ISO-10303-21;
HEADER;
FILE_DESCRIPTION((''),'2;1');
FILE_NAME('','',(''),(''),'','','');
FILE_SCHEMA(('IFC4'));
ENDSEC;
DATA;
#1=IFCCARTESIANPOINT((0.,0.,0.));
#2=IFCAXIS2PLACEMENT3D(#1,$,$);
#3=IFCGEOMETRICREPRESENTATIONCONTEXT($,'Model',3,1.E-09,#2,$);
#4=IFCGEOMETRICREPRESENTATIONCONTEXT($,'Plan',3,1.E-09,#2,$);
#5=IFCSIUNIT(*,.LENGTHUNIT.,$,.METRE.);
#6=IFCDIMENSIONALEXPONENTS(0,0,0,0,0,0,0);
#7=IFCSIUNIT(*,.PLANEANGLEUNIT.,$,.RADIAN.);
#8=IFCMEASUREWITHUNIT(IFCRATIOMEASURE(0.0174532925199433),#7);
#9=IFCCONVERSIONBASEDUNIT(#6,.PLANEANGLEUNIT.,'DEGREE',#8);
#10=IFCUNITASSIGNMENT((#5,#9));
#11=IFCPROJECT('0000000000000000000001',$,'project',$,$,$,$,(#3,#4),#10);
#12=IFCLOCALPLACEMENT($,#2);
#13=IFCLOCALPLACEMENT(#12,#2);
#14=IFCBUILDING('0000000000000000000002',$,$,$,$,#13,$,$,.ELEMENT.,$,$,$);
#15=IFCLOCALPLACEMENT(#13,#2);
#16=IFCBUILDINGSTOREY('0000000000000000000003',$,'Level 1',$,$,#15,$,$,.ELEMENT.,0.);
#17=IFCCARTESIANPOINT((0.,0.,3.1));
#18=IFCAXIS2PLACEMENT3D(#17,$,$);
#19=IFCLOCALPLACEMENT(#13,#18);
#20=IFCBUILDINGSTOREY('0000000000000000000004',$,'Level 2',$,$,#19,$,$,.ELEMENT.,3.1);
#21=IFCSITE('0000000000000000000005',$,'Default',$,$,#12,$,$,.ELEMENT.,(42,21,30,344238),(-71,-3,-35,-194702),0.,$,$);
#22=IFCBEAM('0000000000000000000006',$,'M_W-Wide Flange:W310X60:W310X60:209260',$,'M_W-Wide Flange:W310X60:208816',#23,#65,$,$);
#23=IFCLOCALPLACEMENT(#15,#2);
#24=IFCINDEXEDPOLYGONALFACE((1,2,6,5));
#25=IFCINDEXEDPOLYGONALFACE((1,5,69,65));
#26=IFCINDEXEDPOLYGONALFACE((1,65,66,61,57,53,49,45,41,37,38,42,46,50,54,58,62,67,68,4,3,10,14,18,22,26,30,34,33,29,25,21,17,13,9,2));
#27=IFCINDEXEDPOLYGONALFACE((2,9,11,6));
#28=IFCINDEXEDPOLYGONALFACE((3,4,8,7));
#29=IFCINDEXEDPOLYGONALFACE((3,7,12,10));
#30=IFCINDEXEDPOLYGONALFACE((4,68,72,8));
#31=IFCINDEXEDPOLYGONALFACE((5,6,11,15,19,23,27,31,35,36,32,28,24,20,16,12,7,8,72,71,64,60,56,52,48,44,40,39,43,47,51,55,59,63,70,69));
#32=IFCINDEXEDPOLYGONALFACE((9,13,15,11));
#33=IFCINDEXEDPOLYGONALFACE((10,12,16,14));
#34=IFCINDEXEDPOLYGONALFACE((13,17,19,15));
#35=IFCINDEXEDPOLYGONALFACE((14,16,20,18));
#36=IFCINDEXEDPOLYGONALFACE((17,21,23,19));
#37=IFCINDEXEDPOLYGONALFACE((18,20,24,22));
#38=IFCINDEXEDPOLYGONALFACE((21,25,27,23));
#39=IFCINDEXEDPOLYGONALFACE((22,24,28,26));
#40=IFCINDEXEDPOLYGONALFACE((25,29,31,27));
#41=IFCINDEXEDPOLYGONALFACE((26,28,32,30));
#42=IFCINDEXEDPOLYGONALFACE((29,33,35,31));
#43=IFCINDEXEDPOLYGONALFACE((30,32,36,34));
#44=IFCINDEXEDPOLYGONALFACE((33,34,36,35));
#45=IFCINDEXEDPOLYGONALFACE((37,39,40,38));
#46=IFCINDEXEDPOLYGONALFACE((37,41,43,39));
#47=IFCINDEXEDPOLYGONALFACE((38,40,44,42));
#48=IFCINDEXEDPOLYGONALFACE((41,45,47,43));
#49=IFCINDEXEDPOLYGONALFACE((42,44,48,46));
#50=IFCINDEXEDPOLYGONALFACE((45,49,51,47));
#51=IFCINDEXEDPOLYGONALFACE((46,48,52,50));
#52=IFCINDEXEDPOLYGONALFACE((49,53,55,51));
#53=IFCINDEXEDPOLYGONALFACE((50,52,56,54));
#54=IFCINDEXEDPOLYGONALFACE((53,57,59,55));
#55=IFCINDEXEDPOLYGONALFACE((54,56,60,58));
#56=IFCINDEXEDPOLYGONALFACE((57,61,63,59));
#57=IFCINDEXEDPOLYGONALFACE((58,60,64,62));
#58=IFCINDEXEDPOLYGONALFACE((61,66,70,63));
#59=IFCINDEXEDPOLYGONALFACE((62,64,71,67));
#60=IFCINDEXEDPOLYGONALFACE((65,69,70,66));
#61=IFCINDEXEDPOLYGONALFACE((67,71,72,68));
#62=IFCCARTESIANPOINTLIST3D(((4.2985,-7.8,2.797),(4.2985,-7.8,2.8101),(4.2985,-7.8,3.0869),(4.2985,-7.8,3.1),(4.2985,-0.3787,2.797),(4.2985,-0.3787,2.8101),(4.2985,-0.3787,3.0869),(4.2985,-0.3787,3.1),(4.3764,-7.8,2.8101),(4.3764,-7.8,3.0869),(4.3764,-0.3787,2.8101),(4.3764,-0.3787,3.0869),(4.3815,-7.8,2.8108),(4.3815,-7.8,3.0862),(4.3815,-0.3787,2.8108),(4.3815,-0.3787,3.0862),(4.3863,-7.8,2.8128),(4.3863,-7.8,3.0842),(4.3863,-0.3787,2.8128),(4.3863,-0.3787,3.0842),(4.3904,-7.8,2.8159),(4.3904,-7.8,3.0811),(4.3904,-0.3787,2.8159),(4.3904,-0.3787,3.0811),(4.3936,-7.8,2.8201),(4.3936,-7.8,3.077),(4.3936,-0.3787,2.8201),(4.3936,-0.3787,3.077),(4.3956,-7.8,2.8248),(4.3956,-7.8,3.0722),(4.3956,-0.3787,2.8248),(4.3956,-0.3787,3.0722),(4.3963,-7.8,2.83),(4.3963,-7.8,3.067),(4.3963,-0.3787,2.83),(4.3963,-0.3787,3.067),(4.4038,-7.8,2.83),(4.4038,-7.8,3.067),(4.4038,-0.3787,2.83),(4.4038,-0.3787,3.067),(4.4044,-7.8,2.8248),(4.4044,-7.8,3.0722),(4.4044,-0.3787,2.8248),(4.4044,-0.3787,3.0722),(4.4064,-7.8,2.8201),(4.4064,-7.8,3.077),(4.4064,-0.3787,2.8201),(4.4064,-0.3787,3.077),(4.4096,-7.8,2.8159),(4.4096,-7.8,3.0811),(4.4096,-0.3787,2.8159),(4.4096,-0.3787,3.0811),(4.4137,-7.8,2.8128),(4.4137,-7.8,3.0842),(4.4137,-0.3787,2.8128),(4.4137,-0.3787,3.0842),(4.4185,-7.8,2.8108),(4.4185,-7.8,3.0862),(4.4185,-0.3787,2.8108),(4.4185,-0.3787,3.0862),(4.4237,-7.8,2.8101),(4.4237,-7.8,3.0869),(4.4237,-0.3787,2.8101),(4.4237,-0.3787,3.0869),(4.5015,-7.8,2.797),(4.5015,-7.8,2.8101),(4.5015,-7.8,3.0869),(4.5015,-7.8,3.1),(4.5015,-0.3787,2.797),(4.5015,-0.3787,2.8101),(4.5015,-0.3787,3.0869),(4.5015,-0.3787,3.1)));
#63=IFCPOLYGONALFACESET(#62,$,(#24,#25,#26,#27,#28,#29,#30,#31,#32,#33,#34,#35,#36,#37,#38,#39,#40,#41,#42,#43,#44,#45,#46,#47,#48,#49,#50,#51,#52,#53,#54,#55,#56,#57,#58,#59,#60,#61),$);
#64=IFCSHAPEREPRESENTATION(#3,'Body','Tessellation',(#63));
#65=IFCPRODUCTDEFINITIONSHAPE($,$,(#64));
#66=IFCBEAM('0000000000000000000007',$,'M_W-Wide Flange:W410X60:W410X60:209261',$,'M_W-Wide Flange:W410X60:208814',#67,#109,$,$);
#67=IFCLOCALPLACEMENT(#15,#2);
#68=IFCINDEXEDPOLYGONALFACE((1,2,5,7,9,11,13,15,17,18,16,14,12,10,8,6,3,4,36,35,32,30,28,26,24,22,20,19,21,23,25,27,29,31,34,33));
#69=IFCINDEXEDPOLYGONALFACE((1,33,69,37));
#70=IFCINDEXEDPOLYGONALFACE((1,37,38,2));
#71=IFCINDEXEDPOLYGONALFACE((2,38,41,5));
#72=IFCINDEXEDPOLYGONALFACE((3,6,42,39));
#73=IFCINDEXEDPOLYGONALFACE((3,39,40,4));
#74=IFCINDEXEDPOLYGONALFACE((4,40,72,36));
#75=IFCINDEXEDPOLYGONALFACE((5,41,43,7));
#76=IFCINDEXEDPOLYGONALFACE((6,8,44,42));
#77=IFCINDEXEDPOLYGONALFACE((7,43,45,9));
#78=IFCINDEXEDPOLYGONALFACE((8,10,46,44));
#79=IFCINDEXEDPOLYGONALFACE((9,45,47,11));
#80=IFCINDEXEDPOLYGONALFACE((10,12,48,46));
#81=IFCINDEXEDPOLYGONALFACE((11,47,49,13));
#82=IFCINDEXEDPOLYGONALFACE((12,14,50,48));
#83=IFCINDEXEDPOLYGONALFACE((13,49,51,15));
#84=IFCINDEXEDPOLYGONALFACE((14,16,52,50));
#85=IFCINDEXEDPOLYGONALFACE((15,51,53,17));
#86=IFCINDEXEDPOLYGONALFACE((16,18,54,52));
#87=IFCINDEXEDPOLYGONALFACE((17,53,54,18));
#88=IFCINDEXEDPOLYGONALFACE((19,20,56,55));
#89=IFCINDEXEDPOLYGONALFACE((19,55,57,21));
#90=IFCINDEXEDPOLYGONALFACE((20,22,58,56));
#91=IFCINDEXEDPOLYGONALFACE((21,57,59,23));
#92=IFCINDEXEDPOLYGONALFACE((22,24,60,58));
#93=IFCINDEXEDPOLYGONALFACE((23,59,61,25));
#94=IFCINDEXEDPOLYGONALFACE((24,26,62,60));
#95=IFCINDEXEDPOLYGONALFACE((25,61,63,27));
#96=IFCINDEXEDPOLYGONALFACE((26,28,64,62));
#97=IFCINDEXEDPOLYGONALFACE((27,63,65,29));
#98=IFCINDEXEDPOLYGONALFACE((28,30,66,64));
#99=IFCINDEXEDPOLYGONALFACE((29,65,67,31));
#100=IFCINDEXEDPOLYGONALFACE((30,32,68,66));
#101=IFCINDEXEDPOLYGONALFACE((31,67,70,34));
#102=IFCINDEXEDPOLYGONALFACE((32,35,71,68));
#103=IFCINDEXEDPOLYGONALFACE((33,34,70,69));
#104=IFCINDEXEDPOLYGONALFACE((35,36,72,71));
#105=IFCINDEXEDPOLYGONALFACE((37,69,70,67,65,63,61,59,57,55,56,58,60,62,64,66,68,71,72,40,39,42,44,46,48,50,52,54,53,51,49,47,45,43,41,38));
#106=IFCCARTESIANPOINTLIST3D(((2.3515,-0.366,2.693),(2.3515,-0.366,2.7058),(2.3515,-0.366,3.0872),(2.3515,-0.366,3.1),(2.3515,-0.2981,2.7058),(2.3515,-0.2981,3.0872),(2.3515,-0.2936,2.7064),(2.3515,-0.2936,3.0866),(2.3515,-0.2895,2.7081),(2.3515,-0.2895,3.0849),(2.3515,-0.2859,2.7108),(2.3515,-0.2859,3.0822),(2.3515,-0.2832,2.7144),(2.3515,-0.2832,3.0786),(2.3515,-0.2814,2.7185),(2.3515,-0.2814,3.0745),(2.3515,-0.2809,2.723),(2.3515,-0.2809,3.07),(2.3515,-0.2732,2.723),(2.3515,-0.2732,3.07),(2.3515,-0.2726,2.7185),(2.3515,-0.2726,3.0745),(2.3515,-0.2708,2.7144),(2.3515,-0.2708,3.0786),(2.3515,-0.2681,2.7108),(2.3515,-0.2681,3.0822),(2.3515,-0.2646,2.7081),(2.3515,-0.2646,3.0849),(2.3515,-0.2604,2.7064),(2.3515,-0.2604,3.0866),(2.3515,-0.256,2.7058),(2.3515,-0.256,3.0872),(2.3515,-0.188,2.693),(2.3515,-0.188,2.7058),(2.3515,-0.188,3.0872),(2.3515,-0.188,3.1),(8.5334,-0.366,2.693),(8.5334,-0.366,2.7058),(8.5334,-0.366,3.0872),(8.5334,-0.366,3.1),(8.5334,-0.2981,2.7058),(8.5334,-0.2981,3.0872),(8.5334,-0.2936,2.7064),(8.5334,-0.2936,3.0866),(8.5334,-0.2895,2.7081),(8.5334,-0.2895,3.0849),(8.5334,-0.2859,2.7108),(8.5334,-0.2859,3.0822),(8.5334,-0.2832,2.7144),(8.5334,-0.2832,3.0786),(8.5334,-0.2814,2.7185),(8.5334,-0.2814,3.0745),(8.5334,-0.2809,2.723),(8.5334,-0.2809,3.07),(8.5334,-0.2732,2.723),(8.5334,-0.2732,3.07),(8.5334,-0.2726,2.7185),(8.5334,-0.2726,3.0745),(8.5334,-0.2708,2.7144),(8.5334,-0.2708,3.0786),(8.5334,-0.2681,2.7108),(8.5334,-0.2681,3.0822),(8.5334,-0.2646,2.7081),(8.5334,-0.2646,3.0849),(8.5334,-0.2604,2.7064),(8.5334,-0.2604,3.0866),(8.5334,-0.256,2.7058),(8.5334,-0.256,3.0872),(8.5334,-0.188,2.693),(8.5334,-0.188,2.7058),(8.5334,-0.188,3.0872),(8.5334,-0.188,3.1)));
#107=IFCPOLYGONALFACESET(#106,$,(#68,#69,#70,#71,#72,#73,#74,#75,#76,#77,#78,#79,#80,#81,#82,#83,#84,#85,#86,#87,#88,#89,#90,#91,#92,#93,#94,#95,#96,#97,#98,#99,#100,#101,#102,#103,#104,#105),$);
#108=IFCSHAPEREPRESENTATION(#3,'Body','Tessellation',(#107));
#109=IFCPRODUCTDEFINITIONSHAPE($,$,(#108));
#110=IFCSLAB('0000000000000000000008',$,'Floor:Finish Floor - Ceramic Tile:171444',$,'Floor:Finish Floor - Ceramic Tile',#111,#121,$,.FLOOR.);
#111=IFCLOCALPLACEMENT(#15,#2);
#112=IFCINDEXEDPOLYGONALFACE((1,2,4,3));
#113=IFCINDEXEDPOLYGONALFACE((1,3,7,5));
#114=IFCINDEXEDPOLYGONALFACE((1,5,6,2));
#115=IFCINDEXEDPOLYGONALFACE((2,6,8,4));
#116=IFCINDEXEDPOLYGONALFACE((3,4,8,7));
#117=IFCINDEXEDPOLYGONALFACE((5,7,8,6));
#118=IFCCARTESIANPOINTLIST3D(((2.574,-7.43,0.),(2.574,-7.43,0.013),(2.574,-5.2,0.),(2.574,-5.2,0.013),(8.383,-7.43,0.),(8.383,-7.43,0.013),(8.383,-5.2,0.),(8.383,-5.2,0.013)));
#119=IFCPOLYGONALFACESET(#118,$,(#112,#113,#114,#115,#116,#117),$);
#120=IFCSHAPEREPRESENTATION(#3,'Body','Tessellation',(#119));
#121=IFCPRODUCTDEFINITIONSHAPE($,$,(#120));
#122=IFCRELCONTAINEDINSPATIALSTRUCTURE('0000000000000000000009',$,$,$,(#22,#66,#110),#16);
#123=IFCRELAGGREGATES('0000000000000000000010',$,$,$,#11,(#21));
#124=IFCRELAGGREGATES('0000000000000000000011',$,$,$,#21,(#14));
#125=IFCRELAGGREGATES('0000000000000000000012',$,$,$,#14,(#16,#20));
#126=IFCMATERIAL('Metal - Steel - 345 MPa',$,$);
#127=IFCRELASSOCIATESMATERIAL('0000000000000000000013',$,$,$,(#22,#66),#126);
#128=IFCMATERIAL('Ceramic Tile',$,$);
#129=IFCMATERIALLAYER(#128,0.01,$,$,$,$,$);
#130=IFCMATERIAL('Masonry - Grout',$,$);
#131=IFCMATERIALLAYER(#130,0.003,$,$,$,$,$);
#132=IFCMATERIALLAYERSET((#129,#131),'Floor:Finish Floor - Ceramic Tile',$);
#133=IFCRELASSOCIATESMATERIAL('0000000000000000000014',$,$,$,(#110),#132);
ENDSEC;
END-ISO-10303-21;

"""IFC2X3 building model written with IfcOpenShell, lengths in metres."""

from ifc_helpers import new_model, entity, si_unit, converted_unit, frame, frame_2d, origin, place, context, project, spatial, polyline, circle_curve, parameter, trimmed, segment, composite_curve, rectangle, outline, extrude, material, layer, layer_set, layer_usage, element, save


model = new_model("IFC2X3")

# Units and contexts
model_context = context("Model", 3, precision=1e-09, world=origin())
plan_context = context("Plan", 3, precision=1e-09, world=origin())
ifc_project = project(units=[si_unit("LENGTHUNIT", "METRE"), converted_unit("PLANEANGLEUNIT", "DEGREE", entity("IfcRatioMeasure", 0.0174532925199433), si_unit("PLANEANGLEUNIT", "RADIAN"), dimensions=[0, 0, 0, 0, 0, 0, 0])], contexts=[model_context, plan_context])

# Site, building, storey
site_placement = place(None, origin())
site = spatial("IfcSite", under=ifc_project, at=site_placement, Name="Default", CompositionType="ELEMENT", RefLatitude=(42, 21, 30, 344238), RefLongitude=(-71, -3, -35, -194702), RefElevation=0.0)
building_placement = place(site_placement, origin())
building = spatial("IfcBuilding", under=site, at=building_placement, CompositionType="ELEMENT")
storey_1_placement = place(building_placement, origin())
storey_1 = spatial("IfcBuildingStorey", under=building, at=storey_1_placement, Name="Level 1", CompositionType="ELEMENT", Elevation=0.0)

# Beams
ifc_material_1 = material(Name="Metal - Steel - 345 MPa")
beam_1_placement = place(storey_1_placement, frame((4.4, -7.8, 3.1)))
element("IfcBeam", 1, at=beam_1_placement, inside=storey_1, material=ifc_material_1, Name="M_W-Wide Flange:W310X60:W310X60:209260", ObjectType="M_W-Wide Flange:W310X60:208816", context=model_context, shape_type="SweptSolid", body=[
    extrude(outline(composite_curve([segment(polyline([(-0.1015, -0.1384), (-0.1015, -0.1515)]), True, "CONTINUOUS"), segment(polyline([(-0.1015, -0.1515), (0.1015, -0.1515)]), True, "CONTINUOUS"), segment(polyline([(0.1015, -0.1515), (0.1015, -0.1384)]), True, "CONTINUOUS"), segment(polyline([(0.1015, -0.1384), (0.0236, -0.1384)]), True, "CONTINUOUS"), segment(trimmed(circle_curve(frame_2d((0.0236, -0.1185), x_axis=(1.0, 0.0)), 0.0199), [parameter(180.0)], [parameter(270.0)], True, "PARAMETER"), False, "CONTINUOUS"), segment(polyline([(0.0037, -0.1185), (0.0037, 0.1185)]), True, "CONTINUOUS"), segment(trimmed(circle_curve(frame_2d((0.0236, 0.1185), x_axis=(1.0, 0.0)), 0.0199), [parameter(90.0)], [parameter(180.0)], True, "PARAMETER"), False, "CONTINUOUS"), segment(polyline([(0.0236, 0.1384), (0.1015, 0.1384)]), True, "CONTINUOUS"), segment(polyline([(0.1015, 0.1384), (0.1015, 0.1515)]), True, "CONTINUOUS"), segment(polyline([(0.1015, 0.1515), (-0.1015, 0.1515)]), True, "CONTINUOUS"), segment(polyline([(-0.1015, 0.1515), (-0.1015, 0.1384)]), True, "CONTINUOUS"), segment(polyline([(-0.1015, 0.1384), (-0.0237, 0.1384)]), True, "CONTINUOUS"), segment(trimmed(circle_curve(frame_2d((-0.0237, 0.1185), x_axis=(1.0, 0.0)), 0.0199), [parameter(360.0)], [parameter(90.0)], True, "PARAMETER"), False, "CONTINUOUS"), segment(polyline([(-0.0038, 0.1185), (-0.0038, -0.1185)]), True, "CONTINUOUS"), segment(trimmed(circle_curve(frame_2d((-0.0237, -0.1185), x_axis=(1.0, 0.0)), 0.0199), [parameter(270.0)], [parameter(0.0)], True, "PARAMETER"), False, "CONTINUOUS"), segment(polyline([(-0.0237, -0.1384), (-0.1015, -0.1384)]), True, "CONTINUOUS")], self_intersect=False)), frame((0.0, 0.0, -0.1515), z_axis=(0.0, -1.0, 0.0), x_axis=(1.0, 0.0, 0.0)), (0.0, 0.0, -1.0), 7.4213),
])
beam_2_placement = place(storey_1_placement, frame((8.5915, -0.277, 3.1), z_axis=(0.0, 0.0, 1.0), x_axis=(0.0, 1.0, 0.0)))
element("IfcBeam", 2, at=beam_2_placement, inside=storey_1, material=ifc_material_1, Name="M_W-Wide Flange:W410X60:W410X60:209261", ObjectType="M_W-Wide Flange:W410X60:208814", context=model_context, shape_type="SweptSolid", body=[
    extrude(outline(composite_curve([segment(polyline([(0.1907, -0.089), (0.2035, -0.089)]), True, "CONTINUOUS"), segment(polyline([(0.2035, -0.089), (0.2035, 0.089)]), True, "CONTINUOUS"), segment(polyline([(0.2035, 0.089), (0.1907, 0.089)]), True, "CONTINUOUS"), segment(polyline([(0.1907, 0.089), (0.1907, 0.021)]), True, "CONTINUOUS"), segment(trimmed(circle_curve(frame_2d((0.1735, 0.021), x_axis=(1.0, 0.0)), 0.0172), [parameter(270.0)], [parameter(360.0)], True, "PARAMETER"), False, "CONTINUOUS"), segment(polyline([(0.1735, 0.0038), (-0.1735, 0.0038)]), True, "CONTINUOUS"), segment(trimmed(circle_curve(frame_2d((-0.1735, 0.021), x_axis=(0.0, -1.0)), 0.0172), [parameter(270.0)], [parameter(360.0)], True, "PARAMETER"), False, "CONTINUOUS"), segment(polyline([(-0.1907, 0.021), (-0.1907, 0.089)]), True, "CONTINUOUS"), segment(polyline([(-0.1907, 0.089), (-0.2035, 0.089)]), True, "CONTINUOUS"), segment(polyline([(-0.2035, 0.089), (-0.2035, -0.089)]), True, "CONTINUOUS"), segment(polyline([(-0.2035, -0.089), (-0.1907, -0.089)]), True, "CONTINUOUS"), segment(polyline([(-0.1907, -0.089), (-0.1907, -0.0211)]), True, "CONTINUOUS"), segment(trimmed(circle_curve(frame_2d((-0.1735, -0.0211), x_axis=(-1.0, 0.0)), 0.0172), [parameter(270.0)], [parameter(0.0)], True, "PARAMETER"), False, "CONTINUOUS"), segment(polyline([(-0.1735, -0.0039), (0.1735, -0.0039)]), True, "CONTINUOUS"), segment(trimmed(circle_curve(frame_2d((0.1735, -0.0211), x_axis=(0.0, 1.0)), 0.0172), [parameter(270.0)], [parameter(0.0)], True, "PARAMETER"), False, "CONTINUOUS"), segment(polyline([(0.1907, -0.0211), (0.1907, -0.089)]), True, "CONTINUOUS")], self_intersect=False)), frame((0.0, 6.24, -0.2035), z_axis=(0.0, -1.0, 0.0), x_axis=(0.0, 0.0, -1.0)), (0.0, 0.0, 1.0), 6.1819),
])

# Slab
ifc_material_2 = material(Name="Ceramic Tile")
ifc_layer_1 = layer(ifc_material_2, 0.01)
ifc_material_3 = material(Name="Masonry - Grout")
ifc_layer_2 = layer(ifc_material_3, 0.003)
ifc_layer_set_1 = layer_set([ifc_layer_1, ifc_layer_2], Name="Floor:Finish Floor - Ceramic Tile")
ifc_layer_usage_1 = layer_usage(ifc_layer_set_1, "AXIS3", "POSITIVE", 0.0)
slab_placement = place(storey_1_placement, frame((2.574, -7.43, 0.0)))
element("IfcSlab", 3, at=slab_placement, inside=storey_1, material=ifc_layer_usage_1, Name="Floor:Finish Floor - Ceramic Tile:171444", ObjectType="Floor:Finish Floor - Ceramic Tile", PredefinedType="FLOOR", context=model_context, shape_type="SweptSolid", body=[
    extrude(rectangle(XDim=5.809, YDim=2.23, at=frame_2d((0.0, 0.0), x_axis=(-1.0, 0.0))), frame((2.9045, 1.115, 0.013), z_axis=(0.0, 0.0, -1.0), x_axis=(-1.0, 0.0, 0.0)), (0.0, 0.0, 1.0), 0.013),
])

# Shared definitions
storey_2_placement = place(building_placement, frame((0.0, 0.0, 3.1)))
storey_2 = spatial("IfcBuildingStorey", under=building, at=storey_2_placement, Name="Level 2", CompositionType="ELEMENT", Elevation=3.1)

save(model, "model.ifc")
